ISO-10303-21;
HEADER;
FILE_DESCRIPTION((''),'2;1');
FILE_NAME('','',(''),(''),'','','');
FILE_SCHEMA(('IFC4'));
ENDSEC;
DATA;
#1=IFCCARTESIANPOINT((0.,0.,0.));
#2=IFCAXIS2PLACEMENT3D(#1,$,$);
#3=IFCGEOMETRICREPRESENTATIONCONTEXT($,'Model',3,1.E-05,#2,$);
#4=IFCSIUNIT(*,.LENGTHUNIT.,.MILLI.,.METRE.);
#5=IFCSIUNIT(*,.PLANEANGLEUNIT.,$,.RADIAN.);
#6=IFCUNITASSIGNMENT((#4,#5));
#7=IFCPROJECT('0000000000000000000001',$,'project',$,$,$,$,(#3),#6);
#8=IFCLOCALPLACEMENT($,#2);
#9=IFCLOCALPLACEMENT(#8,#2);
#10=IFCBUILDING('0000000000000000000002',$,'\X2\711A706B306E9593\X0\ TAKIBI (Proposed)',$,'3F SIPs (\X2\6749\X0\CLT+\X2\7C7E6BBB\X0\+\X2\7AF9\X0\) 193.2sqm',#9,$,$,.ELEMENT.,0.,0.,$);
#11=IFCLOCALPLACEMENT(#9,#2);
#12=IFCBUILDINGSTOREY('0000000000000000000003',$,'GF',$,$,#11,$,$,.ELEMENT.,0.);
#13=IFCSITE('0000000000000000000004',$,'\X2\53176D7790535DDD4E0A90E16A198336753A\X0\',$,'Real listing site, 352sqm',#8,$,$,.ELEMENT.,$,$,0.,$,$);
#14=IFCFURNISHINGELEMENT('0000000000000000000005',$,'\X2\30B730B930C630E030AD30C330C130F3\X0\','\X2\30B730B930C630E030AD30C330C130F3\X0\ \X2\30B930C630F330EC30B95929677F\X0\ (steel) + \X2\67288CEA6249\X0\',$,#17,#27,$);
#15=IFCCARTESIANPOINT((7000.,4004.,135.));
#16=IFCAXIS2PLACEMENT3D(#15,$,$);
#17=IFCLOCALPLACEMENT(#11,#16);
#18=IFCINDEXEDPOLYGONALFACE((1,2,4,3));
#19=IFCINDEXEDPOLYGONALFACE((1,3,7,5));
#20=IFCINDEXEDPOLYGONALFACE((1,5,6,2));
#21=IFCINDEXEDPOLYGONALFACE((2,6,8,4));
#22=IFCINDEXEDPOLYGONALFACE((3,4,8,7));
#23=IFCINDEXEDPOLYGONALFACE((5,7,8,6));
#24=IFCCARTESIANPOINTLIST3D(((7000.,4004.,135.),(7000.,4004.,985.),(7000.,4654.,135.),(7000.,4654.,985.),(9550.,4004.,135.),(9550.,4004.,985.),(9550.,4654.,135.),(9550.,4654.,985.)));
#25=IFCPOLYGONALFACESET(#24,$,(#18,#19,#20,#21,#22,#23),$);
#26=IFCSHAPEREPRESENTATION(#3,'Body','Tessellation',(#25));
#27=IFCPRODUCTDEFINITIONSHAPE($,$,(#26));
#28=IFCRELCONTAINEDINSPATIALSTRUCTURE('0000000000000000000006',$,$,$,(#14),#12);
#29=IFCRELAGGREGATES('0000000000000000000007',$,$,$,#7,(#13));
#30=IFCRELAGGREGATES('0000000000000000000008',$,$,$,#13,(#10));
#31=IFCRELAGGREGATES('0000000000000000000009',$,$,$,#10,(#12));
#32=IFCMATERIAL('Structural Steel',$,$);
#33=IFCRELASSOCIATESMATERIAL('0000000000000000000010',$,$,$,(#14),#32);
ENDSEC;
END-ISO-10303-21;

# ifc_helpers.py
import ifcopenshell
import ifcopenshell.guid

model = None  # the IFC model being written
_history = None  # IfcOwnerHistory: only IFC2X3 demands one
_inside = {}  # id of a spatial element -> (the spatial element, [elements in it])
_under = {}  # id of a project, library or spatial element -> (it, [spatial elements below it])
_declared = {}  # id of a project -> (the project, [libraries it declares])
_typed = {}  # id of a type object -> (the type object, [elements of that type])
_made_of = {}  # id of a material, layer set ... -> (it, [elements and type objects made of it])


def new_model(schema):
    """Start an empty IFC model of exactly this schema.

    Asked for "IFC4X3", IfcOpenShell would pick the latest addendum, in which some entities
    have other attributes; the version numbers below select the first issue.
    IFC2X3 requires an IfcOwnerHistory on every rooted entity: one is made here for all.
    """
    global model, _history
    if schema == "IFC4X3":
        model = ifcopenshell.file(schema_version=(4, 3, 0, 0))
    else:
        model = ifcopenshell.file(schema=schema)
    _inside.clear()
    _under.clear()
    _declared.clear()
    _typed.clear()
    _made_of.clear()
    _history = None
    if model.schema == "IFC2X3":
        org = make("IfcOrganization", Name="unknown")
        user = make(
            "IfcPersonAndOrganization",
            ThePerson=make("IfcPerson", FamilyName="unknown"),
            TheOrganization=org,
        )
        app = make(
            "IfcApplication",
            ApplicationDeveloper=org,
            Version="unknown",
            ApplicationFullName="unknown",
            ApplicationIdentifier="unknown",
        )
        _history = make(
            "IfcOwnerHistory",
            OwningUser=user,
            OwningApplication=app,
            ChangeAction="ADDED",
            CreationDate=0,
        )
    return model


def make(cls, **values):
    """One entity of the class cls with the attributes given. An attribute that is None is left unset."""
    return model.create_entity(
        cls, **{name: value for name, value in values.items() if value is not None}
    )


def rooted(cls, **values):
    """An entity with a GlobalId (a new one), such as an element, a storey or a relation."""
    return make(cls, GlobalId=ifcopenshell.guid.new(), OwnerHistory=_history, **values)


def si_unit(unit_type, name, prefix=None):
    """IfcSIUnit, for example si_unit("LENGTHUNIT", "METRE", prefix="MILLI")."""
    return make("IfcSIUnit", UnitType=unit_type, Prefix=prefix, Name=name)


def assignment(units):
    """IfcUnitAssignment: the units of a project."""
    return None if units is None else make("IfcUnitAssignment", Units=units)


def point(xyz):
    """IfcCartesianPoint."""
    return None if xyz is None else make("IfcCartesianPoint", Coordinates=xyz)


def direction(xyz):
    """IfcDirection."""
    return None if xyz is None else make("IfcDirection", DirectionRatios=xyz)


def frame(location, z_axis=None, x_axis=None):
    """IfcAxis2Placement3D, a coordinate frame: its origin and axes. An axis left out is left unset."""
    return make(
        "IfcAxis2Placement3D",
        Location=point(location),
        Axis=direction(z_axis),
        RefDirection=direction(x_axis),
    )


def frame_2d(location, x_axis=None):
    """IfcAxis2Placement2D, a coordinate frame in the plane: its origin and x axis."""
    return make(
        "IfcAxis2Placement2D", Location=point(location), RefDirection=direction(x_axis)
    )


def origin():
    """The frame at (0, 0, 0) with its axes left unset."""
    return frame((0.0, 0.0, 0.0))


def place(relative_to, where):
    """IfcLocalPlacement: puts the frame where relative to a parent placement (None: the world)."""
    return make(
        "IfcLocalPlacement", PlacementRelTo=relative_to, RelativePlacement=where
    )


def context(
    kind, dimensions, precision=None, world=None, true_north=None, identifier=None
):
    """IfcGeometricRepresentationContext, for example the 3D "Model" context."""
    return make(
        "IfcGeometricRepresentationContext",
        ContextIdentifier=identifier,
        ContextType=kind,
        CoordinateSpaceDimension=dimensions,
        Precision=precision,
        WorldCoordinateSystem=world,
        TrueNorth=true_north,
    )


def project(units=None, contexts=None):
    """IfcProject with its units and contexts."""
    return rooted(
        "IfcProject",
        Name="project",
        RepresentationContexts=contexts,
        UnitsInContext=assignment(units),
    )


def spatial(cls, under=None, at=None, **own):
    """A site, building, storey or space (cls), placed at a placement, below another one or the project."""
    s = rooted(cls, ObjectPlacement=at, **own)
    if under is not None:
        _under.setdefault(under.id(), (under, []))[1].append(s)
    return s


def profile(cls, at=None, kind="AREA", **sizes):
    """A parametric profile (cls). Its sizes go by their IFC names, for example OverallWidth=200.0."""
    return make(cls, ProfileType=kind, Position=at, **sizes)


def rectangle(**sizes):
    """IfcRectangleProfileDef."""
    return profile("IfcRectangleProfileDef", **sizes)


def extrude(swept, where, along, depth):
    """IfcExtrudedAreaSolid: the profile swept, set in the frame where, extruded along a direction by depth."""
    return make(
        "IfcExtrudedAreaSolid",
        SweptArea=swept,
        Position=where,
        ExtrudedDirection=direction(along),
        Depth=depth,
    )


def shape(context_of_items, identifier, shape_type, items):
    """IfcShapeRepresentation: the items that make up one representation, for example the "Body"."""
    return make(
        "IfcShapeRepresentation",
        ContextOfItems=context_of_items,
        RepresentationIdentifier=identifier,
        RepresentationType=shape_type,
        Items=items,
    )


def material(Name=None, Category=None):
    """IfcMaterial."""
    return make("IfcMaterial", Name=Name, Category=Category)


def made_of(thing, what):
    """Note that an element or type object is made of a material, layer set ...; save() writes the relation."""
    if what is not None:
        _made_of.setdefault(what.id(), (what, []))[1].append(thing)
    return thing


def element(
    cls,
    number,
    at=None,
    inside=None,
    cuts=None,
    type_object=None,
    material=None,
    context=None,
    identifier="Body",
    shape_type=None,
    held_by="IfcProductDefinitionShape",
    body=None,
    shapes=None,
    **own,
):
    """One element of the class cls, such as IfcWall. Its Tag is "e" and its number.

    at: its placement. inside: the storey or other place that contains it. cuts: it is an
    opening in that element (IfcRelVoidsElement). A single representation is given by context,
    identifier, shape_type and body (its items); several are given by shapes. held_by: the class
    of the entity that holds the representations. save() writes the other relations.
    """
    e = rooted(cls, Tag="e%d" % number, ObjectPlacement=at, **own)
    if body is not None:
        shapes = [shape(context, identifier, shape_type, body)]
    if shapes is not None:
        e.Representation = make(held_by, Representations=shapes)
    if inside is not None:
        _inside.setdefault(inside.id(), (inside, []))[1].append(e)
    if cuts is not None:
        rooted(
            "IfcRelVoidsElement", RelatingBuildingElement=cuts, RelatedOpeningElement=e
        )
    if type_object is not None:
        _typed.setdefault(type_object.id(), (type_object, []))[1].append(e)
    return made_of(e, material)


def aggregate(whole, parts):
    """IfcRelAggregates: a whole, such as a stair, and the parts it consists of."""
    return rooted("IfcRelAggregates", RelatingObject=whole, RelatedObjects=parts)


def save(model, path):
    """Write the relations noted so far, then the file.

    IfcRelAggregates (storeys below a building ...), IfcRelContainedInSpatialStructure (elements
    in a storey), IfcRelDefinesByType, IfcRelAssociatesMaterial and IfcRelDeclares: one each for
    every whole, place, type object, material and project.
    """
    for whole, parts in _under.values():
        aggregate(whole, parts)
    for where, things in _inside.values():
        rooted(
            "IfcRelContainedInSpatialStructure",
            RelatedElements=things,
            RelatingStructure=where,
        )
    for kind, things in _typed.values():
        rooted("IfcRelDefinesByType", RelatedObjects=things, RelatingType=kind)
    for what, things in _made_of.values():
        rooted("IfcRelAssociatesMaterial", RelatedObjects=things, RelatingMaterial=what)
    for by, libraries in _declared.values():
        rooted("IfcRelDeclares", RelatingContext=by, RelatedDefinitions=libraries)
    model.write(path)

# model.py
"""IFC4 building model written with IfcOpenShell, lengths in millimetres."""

from ifc_helpers import new_model, si_unit, frame, frame_2d, origin, place, context, project, spatial, rectangle, extrude, material, element, save


model = new_model("IFC4")

# Units and contexts
model_context = context("Model", 3, precision=1e-05, world=origin())
ifc_project = project(units=[si_unit("LENGTHUNIT", "METRE", prefix="MILLI"), si_unit("PLANEANGLEUNIT", "RADIAN")], contexts=[model_context])

# Site, building, storey
site_placement = place(None, origin())
site = spatial("IfcSite", under=ifc_project, at=site_placement, Name="北海道川上郡標茶町", ObjectType="Real listing site, 352sqm", CompositionType="ELEMENT", RefElevation=0.0)
building_placement = place(site_placement, origin())
building = spatial("IfcBuilding", under=site, at=building_placement, Name="焚火の間 TAKIBI (Proposed)", ObjectType="3F SIPs (杉CLT+籾殻+竹) 193.2sqm", CompositionType="ELEMENT", ElevationOfRefHeight=0.0, ElevationOfTerrain=0.0)
storey_placement = place(building_placement, origin())
storey = spatial("IfcBuildingStorey", under=building, at=storey_placement, Name="GF", CompositionType="ELEMENT", Elevation=0.0)

# Furnishing element
ifc_material_1 = material(Name="Structural Steel")
furnishing_1_placement = place(storey_placement, frame((7000.0, 4004.0, 135.0)))
element("IfcFurnishingElement", 1, at=furnishing_1_placement, inside=storey, material=ifc_material_1, Name="システムキッチン", Description="システムキッチン ステンレス天板 (steel) + 木質扉", context=model_context, shape_type="SweptSolid", body=[
    extrude(rectangle(XDim=2550.0, YDim=650.0, at=frame_2d((1275.0, 325.0))), frame((7000.0, 4004.0, 135.0)), (0.0, 0.0, 1.0), 850.0),
])

save(model, "model.ifc")
